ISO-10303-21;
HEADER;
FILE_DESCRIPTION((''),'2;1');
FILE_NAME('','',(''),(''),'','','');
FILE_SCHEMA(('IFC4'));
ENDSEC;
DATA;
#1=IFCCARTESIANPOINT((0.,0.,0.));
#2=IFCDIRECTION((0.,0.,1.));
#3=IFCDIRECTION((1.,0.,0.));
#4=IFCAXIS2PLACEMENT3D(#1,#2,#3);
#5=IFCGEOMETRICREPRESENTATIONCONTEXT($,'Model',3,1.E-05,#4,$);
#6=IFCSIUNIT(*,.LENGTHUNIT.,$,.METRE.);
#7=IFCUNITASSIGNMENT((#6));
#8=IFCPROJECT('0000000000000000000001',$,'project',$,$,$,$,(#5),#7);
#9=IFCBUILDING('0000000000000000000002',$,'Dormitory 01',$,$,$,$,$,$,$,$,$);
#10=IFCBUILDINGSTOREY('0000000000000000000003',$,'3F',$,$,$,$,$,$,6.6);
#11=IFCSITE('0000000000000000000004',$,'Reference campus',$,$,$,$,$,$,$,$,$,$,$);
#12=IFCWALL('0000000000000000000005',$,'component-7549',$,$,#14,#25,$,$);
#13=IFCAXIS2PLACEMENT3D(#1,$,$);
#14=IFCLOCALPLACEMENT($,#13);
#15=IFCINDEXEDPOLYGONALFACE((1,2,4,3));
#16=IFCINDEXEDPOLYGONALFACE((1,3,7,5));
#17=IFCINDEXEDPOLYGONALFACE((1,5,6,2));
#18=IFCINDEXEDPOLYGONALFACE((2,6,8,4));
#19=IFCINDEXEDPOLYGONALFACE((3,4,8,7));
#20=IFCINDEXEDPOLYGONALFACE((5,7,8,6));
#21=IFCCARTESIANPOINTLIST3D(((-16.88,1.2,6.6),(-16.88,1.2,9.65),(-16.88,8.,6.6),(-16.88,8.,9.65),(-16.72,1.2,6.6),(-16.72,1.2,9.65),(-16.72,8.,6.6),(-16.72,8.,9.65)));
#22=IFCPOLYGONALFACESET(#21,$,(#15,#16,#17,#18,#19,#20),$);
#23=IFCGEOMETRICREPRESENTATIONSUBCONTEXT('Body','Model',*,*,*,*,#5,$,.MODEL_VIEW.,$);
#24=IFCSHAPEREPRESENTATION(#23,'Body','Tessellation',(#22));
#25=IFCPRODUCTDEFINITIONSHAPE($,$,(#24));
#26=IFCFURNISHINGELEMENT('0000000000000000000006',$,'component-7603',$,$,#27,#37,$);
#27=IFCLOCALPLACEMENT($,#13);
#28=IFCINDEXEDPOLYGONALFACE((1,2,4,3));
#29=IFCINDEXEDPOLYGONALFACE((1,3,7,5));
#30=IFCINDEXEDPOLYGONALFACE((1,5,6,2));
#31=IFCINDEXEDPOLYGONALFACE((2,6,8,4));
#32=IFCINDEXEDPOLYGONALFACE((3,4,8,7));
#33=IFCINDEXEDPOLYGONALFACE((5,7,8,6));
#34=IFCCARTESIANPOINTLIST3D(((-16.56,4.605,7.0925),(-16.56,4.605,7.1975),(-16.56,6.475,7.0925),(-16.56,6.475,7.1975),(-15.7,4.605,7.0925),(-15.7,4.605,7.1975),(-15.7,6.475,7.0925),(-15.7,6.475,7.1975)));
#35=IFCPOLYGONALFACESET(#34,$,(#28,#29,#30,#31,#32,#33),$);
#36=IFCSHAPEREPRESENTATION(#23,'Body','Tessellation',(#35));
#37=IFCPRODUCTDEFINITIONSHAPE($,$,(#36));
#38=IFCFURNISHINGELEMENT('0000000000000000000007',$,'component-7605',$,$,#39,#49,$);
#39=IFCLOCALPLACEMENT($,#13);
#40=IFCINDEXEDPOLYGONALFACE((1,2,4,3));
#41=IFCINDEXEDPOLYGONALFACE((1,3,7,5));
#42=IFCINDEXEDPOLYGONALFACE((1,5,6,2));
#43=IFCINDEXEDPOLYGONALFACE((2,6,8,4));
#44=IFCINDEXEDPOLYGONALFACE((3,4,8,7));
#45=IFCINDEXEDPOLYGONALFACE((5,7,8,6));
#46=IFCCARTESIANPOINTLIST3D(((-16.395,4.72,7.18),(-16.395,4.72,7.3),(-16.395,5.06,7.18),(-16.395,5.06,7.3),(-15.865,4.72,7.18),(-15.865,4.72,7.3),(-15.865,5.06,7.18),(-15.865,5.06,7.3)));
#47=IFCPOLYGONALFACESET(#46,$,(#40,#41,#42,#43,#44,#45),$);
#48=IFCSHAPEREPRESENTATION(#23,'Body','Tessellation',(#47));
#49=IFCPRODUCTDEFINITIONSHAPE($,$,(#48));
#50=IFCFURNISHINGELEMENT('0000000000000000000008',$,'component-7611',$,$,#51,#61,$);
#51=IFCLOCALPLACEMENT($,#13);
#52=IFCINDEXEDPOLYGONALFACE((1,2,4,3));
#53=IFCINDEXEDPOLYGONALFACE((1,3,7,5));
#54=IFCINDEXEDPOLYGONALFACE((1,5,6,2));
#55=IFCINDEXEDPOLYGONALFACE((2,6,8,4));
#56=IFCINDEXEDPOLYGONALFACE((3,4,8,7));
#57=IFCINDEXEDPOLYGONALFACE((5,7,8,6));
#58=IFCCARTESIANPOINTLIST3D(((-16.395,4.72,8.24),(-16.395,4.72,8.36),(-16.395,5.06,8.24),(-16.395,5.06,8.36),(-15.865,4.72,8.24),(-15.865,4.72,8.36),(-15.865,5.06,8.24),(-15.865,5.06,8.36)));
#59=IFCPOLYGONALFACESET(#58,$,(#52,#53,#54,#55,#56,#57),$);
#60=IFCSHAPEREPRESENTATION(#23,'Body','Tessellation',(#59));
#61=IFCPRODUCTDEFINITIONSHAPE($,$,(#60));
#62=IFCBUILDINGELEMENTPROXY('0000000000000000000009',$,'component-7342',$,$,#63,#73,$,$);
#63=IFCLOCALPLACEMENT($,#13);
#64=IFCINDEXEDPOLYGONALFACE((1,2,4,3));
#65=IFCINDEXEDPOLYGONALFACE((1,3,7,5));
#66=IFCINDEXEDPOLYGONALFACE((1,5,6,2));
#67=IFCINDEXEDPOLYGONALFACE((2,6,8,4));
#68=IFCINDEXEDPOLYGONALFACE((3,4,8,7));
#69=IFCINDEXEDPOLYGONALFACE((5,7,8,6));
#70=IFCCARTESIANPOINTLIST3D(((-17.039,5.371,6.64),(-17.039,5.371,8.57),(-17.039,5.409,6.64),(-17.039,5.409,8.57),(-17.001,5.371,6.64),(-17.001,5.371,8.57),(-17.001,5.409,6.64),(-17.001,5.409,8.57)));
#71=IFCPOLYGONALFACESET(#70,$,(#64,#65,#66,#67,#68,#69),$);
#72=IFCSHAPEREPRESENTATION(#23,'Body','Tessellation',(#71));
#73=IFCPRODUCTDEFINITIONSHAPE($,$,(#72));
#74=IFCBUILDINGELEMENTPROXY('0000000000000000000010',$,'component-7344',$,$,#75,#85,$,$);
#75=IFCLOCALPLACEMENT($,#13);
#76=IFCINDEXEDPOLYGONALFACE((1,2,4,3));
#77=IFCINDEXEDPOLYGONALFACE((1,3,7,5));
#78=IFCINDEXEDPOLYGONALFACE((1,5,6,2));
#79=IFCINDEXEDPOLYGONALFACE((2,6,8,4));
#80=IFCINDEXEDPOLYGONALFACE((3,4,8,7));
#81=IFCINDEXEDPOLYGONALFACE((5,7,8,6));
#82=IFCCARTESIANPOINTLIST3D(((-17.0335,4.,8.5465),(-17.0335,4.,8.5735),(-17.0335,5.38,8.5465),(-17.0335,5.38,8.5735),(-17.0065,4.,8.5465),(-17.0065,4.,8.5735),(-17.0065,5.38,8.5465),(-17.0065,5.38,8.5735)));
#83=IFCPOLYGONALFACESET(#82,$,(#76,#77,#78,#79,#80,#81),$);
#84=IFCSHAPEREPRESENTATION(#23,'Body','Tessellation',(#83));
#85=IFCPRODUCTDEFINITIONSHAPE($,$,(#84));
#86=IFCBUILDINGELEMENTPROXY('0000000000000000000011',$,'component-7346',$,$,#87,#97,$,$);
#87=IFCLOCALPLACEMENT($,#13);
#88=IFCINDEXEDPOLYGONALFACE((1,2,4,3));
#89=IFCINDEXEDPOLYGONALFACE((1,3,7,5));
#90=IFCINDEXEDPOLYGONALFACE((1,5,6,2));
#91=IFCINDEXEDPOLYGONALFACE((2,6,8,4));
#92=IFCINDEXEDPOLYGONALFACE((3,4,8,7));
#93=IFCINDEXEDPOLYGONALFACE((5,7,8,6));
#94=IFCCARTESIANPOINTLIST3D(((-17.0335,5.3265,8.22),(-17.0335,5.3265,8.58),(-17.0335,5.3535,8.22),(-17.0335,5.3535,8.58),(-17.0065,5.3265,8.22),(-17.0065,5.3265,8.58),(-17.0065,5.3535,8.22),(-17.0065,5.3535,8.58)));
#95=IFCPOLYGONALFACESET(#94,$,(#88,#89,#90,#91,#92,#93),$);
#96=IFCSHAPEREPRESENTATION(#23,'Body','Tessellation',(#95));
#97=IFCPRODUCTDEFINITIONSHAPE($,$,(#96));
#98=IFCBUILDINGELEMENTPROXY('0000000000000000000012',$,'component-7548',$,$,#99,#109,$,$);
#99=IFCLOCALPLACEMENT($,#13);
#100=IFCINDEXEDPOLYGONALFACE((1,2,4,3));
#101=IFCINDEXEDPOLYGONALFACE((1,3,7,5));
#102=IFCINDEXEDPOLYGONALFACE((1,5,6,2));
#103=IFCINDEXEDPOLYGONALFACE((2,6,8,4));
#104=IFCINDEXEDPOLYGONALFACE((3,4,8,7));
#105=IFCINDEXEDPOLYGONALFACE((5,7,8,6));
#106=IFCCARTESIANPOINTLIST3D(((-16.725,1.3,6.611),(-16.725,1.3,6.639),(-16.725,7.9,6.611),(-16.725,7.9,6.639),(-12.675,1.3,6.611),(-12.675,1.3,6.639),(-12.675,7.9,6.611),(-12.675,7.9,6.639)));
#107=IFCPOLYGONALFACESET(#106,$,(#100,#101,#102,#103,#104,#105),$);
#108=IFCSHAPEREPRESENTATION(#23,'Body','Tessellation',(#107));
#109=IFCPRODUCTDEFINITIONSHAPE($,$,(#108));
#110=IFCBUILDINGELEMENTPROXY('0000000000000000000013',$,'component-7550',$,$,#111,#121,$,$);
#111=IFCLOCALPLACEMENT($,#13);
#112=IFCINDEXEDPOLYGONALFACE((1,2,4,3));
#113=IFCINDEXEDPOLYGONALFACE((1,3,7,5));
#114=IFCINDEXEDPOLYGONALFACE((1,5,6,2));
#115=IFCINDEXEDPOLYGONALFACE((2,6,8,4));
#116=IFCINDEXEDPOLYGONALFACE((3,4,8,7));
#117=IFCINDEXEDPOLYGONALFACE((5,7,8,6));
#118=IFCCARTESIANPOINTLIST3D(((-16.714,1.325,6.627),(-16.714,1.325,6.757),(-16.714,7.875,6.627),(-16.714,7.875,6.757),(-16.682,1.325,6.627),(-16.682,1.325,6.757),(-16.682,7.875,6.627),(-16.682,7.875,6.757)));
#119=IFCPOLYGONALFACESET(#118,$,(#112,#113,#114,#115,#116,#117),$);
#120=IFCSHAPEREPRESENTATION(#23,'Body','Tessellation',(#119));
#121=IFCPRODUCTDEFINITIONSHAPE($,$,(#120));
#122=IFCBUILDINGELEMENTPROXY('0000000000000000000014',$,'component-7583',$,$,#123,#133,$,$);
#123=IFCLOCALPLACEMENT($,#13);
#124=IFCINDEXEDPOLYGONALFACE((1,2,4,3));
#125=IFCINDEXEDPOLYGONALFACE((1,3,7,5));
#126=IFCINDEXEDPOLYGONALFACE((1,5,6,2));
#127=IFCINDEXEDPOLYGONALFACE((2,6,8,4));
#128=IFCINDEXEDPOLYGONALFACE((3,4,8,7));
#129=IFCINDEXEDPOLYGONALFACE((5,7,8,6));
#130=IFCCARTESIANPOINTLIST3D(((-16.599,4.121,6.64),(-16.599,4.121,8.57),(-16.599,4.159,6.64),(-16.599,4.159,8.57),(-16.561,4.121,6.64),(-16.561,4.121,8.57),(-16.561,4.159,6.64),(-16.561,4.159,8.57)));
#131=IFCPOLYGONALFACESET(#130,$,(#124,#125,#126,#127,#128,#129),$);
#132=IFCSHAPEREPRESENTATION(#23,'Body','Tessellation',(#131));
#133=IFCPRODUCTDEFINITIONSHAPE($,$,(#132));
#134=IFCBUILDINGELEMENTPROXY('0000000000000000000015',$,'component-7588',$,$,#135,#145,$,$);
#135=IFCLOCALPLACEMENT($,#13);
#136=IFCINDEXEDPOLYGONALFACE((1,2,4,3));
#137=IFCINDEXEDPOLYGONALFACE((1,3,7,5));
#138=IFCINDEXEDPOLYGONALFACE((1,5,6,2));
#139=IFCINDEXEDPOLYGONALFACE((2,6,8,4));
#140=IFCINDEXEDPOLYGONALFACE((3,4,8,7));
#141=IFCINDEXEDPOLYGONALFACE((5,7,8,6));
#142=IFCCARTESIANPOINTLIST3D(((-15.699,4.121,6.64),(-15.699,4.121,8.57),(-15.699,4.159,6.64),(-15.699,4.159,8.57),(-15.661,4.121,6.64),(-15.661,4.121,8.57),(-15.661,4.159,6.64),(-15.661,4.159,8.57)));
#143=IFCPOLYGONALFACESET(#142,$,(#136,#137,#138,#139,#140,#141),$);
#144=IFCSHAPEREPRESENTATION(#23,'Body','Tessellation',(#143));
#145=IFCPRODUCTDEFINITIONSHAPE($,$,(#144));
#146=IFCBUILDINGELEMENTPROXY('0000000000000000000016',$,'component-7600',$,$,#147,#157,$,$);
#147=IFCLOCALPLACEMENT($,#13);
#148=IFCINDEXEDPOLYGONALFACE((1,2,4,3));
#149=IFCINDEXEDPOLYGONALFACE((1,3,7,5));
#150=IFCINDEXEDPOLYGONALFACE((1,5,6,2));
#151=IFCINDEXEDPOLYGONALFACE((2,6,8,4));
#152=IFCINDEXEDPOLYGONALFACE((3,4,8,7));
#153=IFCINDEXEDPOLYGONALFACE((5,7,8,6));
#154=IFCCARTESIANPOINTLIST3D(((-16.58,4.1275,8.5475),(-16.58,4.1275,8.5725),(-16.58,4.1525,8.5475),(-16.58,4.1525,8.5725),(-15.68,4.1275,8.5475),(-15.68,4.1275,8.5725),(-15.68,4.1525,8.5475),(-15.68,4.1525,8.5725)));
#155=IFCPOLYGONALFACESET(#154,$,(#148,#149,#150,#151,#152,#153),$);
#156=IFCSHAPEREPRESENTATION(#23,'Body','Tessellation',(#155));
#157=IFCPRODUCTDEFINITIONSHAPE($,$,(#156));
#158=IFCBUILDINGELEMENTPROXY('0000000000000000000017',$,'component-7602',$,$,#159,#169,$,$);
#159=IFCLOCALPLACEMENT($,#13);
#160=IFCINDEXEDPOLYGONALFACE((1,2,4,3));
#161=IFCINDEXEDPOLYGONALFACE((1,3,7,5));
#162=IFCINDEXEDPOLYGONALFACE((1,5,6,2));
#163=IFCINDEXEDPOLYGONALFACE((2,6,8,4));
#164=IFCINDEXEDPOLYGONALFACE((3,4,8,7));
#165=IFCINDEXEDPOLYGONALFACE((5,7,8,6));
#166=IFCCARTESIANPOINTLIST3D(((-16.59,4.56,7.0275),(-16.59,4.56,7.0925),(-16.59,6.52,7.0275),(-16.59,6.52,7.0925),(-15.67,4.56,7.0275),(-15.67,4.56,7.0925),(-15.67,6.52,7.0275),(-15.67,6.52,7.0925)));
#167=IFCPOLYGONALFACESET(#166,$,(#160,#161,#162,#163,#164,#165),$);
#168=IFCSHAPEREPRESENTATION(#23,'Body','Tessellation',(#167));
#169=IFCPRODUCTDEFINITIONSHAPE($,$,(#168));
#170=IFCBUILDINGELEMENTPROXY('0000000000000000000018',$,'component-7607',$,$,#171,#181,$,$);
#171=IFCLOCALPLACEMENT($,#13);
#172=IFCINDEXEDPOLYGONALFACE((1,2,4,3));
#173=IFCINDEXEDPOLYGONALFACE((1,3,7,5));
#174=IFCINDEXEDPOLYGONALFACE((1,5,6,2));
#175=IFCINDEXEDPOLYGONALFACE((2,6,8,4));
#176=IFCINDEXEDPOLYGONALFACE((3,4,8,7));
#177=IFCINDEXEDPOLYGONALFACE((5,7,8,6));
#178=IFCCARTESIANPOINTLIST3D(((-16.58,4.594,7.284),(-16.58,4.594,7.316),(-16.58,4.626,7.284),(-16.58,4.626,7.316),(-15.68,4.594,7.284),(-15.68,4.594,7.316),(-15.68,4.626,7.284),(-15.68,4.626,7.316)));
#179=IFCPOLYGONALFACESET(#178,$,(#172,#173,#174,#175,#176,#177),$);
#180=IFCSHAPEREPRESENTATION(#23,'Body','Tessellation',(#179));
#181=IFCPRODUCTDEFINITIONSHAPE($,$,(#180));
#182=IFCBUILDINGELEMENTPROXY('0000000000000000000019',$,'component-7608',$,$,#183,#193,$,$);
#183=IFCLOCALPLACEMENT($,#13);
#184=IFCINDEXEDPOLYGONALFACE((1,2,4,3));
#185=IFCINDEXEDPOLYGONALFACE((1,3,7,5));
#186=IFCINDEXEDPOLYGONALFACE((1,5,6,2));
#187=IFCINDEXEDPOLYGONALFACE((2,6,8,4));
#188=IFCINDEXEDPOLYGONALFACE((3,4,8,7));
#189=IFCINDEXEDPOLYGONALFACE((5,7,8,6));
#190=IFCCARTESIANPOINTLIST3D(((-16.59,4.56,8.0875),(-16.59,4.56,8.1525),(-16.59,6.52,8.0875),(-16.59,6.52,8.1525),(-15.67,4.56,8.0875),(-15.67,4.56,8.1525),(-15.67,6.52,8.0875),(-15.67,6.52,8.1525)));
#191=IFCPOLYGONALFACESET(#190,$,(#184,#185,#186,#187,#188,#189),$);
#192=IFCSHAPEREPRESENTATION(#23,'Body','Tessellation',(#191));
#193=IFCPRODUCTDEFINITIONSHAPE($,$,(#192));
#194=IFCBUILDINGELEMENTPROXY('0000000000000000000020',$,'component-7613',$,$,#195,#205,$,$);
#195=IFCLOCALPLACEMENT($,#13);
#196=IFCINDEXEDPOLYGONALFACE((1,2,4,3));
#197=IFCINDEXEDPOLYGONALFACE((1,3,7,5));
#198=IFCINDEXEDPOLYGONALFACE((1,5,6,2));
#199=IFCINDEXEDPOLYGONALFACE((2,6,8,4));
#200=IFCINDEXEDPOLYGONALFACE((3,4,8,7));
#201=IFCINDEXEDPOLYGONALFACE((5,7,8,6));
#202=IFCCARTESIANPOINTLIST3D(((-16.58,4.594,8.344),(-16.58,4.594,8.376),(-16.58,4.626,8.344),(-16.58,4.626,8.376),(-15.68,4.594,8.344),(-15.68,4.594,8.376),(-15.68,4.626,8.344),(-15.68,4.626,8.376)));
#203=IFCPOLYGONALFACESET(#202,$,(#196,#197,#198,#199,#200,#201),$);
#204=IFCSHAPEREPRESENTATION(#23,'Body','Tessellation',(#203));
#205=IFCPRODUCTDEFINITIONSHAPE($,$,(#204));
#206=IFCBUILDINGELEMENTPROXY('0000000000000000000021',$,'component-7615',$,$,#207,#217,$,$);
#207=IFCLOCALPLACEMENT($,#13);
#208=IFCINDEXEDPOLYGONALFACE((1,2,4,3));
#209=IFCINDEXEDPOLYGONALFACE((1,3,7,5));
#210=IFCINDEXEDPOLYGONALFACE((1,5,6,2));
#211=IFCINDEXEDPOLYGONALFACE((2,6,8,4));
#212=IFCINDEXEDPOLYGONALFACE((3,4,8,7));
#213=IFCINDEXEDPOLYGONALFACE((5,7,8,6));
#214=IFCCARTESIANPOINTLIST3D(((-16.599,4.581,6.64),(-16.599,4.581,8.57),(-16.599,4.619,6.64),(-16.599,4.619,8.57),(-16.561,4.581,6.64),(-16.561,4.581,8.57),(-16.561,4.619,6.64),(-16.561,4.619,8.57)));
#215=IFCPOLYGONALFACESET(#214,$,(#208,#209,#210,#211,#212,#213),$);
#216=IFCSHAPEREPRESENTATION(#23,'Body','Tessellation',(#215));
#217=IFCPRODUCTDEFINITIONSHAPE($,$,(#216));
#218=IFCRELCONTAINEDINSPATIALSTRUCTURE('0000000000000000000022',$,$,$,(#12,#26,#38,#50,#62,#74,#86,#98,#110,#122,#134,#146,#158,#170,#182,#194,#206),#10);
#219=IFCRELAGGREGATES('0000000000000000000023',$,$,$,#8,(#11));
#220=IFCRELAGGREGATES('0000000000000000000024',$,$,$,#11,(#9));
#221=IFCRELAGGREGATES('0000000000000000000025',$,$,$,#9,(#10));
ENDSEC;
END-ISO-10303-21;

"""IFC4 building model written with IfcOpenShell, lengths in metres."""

from ifc_helpers import new_model, si_unit, frame, origin, origin_with_axes, origin_2d, place, context, subcontext, project, spatial, rectangle, extrude, element, save


model = new_model("IFC4")

# Units and contexts
model_context = context("Model", 3, precision=1e-05, world=origin_with_axes())
body_context = subcontext(model_context, "Body", "Model", "MODEL_VIEW")
ifc_project = project(units=[si_unit("LENGTHUNIT", "METRE")], contexts=[model_context])

# Site, building, storey
site = spatial("IfcSite", under=ifc_project, Name="Reference campus")
building = spatial("IfcBuilding", under=site, Name="Dormitory 01")
storey = spatial("IfcBuildingStorey", under=building, Name="3F", Elevation=6.6)

# Wall
wall_placement = place(None, frame((-16.8, 4.6, 6.6), z_axis=(0.0, 0.0, 1.0), x_axis=(1.0, 0.0, 0.0)))
element("IfcWall", 1, at=wall_placement, inside=storey, Name="component-7549", context=body_context, shape_type="SweptSolid", body=[
    extrude(rectangle(XDim=0.16, YDim=6.8, at=origin_2d()), origin(), (0.0, 0.0, 1.0), 3.05),
])

# Furnishing elements
furnishing_placement = place(None, frame((-16.13, 5.54, 7.0925), z_axis=(0.0, 0.0, 1.0), x_axis=(1.0, 0.0, 0.0)))
element("IfcFurnishingElement", 2, at=furnishing_placement, inside=storey, Name="component-7603", context=body_context, shape_type="SweptSolid", body=[
    extrude(rectangle(XDim=0.86, YDim=1.87, at=origin_2d()), origin(), (0.0, 0.0, 1.0), 0.105),
])
for number, where, z_axis, x_axis, name in (
    (3, (-16.13, 4.89, 7.18), (0.0, 0.0, 1.0), (1.0, 0.0, 0.0), "component-7605"),
    (4, (-16.13, 4.89, 8.24), (0.0, 0.0, 1.0), (1.0, 0.0, 0.0), "component-7611"),
):
    element("IfcFurnishingElement", number, at=place(None, frame(where, z_axis=z_axis, x_axis=x_axis)), inside=storey, Name=name, context=body_context, shape_type="SweptSolid", body=[
        extrude(rectangle(XDim=0.53, YDim=0.34, at=origin_2d()), origin(), (0.0, 0.0, 1.0), 0.12),
    ])

# Building element proxies
proxy_1_placement = place(None, frame((-17.02, 5.39, 6.64), z_axis=(0.0, 0.0, 1.0), x_axis=(1.0, 0.0, 0.0)))
element("IfcBuildingElementProxy", 5, at=proxy_1_placement, inside=storey, Name="component-7342", context=body_context, shape_type="SweptSolid", body=[
    extrude(rectangle(XDim=0.038, YDim=0.038, at=origin_2d()), origin(), (0.0, 0.0, 1.0), 1.93),
])
proxy_2_placement = place(None, frame((-17.02, 4.69, 8.5465), z_axis=(0.0, 0.0, 1.0), x_axis=(1.0, 0.0, 0.0)))
element("IfcBuildingElementProxy", 6, at=proxy_2_placement, inside=storey, Name="component-7344", context=body_context, shape_type="SweptSolid", body=[
    extrude(rectangle(XDim=0.027, YDim=1.38, at=origin_2d()), origin(), (0.0, 0.0, 1.0), 0.027),
])
proxy_3_placement = place(None, frame((-17.02, 5.34, 8.22), z_axis=(0.0, 0.0, 1.0), x_axis=(1.0, 0.0, 0.0)))
element("IfcBuildingElementProxy", 7, at=proxy_3_placement, inside=storey, Name="component-7346", context=body_context, shape_type="SweptSolid", body=[
    extrude(rectangle(XDim=0.027, YDim=0.027, at=origin_2d()), origin(), (0.0, 0.0, 1.0), 0.36),
])
proxy_4_placement = place(None, frame((-14.7, 4.6, 6.611), z_axis=(0.0, 0.0, 1.0), x_axis=(1.0, 0.0, 0.0)))
element("IfcBuildingElementProxy", 8, at=proxy_4_placement, inside=storey, Name="component-7548", context=body_context, shape_type="SweptSolid", body=[
    extrude(rectangle(XDim=4.05, YDim=6.6, at=origin_2d()), origin(), (0.0, 0.0, 1.0), 0.028),
])
proxy_5_placement = place(None, frame((-16.698, 4.6, 6.627), z_axis=(0.0, 0.0, 1.0), x_axis=(1.0, 0.0, 0.0)))
element("IfcBuildingElementProxy", 9, at=proxy_5_placement, inside=storey, Name="component-7550", context=body_context, shape_type="SweptSolid", body=[
    extrude(rectangle(XDim=0.032, YDim=6.55, at=origin_2d()), origin(), (0.0, 0.0, 1.0), 0.13),
])
for number, where, z_axis, x_axis, name in (
    (10, (-16.58, 4.14, 6.64), (0.0, 0.0, 1.0), (1.0, 0.0, 0.0), "component-7583"),
    (11, (-15.68, 4.14, 6.64), (0.0, 0.0, 1.0), (1.0, 0.0, 0.0), "component-7588"),
):
    element("IfcBuildingElementProxy", number, at=place(None, frame(where, z_axis=z_axis, x_axis=x_axis)), inside=storey, Name=name, context=body_context, shape_type="SweptSolid", body=[
        extrude(rectangle(XDim=0.038, YDim=0.038, at=origin_2d()), origin(), (0.0, 0.0, 1.0), 1.93),
    ])
proxy_6_placement = place(None, frame((-16.13, 4.14, 8.5475), z_axis=(0.0, 0.0, 1.0), x_axis=(1.0, 0.0, 0.0)))
element("IfcBuildingElementProxy", 12, at=proxy_6_placement, inside=storey, Name="component-7600", context=body_context, shape_type="SweptSolid", body=[
    extrude(rectangle(XDim=0.9, YDim=0.025, at=origin_2d()), origin(), (0.0, 0.0, 1.0), 0.025),
])
proxy_7_placement = place(None, frame((-16.13, 5.54, 7.0275), z_axis=(0.0, 0.0, 1.0), x_axis=(1.0, 0.0, 0.0)))
element("IfcBuildingElementProxy", 13, at=proxy_7_placement, inside=storey, Name="component-7602", context=body_context, shape_type="SweptSolid", body=[
    extrude(rectangle(XDim=0.92, YDim=1.96, at=origin_2d()), origin(), (0.0, 0.0, 1.0), 0.065),
])
proxy_8_placement = place(None, frame((-16.13, 4.61, 7.284), z_axis=(0.0, 0.0, 1.0), x_axis=(1.0, 0.0, 0.0)))
element("IfcBuildingElementProxy", 14, at=proxy_8_placement, inside=storey, Name="component-7607", context=body_context, shape_type="SweptSolid", body=[
    extrude(rectangle(XDim=0.9, YDim=0.032, at=origin_2d()), origin(), (0.0, 0.0, 1.0), 0.032),
])
proxy_9_placement = place(None, frame((-16.13, 5.54, 8.0875), z_axis=(0.0, 0.0, 1.0), x_axis=(1.0, 0.0, 0.0)))
element("IfcBuildingElementProxy", 15, at=proxy_9_placement, inside=storey, Name="component-7608", context=body_context, shape_type="SweptSolid", body=[
    extrude(rectangle(XDim=0.92, YDim=1.96, at=origin_2d()), origin(), (0.0, 0.0, 1.0), 0.065),
])
proxy_10_placement = place(None, frame((-16.13, 4.61, 8.344), z_axis=(0.0, 0.0, 1.0), x_axis=(1.0, 0.0, 0.0)))
element("IfcBuildingElementProxy", 16, at=proxy_10_placement, inside=storey, Name="component-7613", context=body_context, shape_type="SweptSolid", body=[
    extrude(rectangle(XDim=0.9, YDim=0.032, at=origin_2d()), origin(), (0.0, 0.0, 1.0), 0.032),
])
proxy_11_placement = place(None, frame((-16.58, 4.6, 6.64), z_axis=(0.0, 0.0, 1.0), x_axis=(1.0, 0.0, 0.0)))
element("IfcBuildingElementProxy", 17, at=proxy_11_placement, inside=storey, Name="component-7615", context=body_context, shape_type="SweptSolid", body=[
    extrude(rectangle(XDim=0.038, YDim=0.038, at=origin_2d()), origin(), (0.0, 0.0, 1.0), 1.93),
])

save(model, "model.ifc")
